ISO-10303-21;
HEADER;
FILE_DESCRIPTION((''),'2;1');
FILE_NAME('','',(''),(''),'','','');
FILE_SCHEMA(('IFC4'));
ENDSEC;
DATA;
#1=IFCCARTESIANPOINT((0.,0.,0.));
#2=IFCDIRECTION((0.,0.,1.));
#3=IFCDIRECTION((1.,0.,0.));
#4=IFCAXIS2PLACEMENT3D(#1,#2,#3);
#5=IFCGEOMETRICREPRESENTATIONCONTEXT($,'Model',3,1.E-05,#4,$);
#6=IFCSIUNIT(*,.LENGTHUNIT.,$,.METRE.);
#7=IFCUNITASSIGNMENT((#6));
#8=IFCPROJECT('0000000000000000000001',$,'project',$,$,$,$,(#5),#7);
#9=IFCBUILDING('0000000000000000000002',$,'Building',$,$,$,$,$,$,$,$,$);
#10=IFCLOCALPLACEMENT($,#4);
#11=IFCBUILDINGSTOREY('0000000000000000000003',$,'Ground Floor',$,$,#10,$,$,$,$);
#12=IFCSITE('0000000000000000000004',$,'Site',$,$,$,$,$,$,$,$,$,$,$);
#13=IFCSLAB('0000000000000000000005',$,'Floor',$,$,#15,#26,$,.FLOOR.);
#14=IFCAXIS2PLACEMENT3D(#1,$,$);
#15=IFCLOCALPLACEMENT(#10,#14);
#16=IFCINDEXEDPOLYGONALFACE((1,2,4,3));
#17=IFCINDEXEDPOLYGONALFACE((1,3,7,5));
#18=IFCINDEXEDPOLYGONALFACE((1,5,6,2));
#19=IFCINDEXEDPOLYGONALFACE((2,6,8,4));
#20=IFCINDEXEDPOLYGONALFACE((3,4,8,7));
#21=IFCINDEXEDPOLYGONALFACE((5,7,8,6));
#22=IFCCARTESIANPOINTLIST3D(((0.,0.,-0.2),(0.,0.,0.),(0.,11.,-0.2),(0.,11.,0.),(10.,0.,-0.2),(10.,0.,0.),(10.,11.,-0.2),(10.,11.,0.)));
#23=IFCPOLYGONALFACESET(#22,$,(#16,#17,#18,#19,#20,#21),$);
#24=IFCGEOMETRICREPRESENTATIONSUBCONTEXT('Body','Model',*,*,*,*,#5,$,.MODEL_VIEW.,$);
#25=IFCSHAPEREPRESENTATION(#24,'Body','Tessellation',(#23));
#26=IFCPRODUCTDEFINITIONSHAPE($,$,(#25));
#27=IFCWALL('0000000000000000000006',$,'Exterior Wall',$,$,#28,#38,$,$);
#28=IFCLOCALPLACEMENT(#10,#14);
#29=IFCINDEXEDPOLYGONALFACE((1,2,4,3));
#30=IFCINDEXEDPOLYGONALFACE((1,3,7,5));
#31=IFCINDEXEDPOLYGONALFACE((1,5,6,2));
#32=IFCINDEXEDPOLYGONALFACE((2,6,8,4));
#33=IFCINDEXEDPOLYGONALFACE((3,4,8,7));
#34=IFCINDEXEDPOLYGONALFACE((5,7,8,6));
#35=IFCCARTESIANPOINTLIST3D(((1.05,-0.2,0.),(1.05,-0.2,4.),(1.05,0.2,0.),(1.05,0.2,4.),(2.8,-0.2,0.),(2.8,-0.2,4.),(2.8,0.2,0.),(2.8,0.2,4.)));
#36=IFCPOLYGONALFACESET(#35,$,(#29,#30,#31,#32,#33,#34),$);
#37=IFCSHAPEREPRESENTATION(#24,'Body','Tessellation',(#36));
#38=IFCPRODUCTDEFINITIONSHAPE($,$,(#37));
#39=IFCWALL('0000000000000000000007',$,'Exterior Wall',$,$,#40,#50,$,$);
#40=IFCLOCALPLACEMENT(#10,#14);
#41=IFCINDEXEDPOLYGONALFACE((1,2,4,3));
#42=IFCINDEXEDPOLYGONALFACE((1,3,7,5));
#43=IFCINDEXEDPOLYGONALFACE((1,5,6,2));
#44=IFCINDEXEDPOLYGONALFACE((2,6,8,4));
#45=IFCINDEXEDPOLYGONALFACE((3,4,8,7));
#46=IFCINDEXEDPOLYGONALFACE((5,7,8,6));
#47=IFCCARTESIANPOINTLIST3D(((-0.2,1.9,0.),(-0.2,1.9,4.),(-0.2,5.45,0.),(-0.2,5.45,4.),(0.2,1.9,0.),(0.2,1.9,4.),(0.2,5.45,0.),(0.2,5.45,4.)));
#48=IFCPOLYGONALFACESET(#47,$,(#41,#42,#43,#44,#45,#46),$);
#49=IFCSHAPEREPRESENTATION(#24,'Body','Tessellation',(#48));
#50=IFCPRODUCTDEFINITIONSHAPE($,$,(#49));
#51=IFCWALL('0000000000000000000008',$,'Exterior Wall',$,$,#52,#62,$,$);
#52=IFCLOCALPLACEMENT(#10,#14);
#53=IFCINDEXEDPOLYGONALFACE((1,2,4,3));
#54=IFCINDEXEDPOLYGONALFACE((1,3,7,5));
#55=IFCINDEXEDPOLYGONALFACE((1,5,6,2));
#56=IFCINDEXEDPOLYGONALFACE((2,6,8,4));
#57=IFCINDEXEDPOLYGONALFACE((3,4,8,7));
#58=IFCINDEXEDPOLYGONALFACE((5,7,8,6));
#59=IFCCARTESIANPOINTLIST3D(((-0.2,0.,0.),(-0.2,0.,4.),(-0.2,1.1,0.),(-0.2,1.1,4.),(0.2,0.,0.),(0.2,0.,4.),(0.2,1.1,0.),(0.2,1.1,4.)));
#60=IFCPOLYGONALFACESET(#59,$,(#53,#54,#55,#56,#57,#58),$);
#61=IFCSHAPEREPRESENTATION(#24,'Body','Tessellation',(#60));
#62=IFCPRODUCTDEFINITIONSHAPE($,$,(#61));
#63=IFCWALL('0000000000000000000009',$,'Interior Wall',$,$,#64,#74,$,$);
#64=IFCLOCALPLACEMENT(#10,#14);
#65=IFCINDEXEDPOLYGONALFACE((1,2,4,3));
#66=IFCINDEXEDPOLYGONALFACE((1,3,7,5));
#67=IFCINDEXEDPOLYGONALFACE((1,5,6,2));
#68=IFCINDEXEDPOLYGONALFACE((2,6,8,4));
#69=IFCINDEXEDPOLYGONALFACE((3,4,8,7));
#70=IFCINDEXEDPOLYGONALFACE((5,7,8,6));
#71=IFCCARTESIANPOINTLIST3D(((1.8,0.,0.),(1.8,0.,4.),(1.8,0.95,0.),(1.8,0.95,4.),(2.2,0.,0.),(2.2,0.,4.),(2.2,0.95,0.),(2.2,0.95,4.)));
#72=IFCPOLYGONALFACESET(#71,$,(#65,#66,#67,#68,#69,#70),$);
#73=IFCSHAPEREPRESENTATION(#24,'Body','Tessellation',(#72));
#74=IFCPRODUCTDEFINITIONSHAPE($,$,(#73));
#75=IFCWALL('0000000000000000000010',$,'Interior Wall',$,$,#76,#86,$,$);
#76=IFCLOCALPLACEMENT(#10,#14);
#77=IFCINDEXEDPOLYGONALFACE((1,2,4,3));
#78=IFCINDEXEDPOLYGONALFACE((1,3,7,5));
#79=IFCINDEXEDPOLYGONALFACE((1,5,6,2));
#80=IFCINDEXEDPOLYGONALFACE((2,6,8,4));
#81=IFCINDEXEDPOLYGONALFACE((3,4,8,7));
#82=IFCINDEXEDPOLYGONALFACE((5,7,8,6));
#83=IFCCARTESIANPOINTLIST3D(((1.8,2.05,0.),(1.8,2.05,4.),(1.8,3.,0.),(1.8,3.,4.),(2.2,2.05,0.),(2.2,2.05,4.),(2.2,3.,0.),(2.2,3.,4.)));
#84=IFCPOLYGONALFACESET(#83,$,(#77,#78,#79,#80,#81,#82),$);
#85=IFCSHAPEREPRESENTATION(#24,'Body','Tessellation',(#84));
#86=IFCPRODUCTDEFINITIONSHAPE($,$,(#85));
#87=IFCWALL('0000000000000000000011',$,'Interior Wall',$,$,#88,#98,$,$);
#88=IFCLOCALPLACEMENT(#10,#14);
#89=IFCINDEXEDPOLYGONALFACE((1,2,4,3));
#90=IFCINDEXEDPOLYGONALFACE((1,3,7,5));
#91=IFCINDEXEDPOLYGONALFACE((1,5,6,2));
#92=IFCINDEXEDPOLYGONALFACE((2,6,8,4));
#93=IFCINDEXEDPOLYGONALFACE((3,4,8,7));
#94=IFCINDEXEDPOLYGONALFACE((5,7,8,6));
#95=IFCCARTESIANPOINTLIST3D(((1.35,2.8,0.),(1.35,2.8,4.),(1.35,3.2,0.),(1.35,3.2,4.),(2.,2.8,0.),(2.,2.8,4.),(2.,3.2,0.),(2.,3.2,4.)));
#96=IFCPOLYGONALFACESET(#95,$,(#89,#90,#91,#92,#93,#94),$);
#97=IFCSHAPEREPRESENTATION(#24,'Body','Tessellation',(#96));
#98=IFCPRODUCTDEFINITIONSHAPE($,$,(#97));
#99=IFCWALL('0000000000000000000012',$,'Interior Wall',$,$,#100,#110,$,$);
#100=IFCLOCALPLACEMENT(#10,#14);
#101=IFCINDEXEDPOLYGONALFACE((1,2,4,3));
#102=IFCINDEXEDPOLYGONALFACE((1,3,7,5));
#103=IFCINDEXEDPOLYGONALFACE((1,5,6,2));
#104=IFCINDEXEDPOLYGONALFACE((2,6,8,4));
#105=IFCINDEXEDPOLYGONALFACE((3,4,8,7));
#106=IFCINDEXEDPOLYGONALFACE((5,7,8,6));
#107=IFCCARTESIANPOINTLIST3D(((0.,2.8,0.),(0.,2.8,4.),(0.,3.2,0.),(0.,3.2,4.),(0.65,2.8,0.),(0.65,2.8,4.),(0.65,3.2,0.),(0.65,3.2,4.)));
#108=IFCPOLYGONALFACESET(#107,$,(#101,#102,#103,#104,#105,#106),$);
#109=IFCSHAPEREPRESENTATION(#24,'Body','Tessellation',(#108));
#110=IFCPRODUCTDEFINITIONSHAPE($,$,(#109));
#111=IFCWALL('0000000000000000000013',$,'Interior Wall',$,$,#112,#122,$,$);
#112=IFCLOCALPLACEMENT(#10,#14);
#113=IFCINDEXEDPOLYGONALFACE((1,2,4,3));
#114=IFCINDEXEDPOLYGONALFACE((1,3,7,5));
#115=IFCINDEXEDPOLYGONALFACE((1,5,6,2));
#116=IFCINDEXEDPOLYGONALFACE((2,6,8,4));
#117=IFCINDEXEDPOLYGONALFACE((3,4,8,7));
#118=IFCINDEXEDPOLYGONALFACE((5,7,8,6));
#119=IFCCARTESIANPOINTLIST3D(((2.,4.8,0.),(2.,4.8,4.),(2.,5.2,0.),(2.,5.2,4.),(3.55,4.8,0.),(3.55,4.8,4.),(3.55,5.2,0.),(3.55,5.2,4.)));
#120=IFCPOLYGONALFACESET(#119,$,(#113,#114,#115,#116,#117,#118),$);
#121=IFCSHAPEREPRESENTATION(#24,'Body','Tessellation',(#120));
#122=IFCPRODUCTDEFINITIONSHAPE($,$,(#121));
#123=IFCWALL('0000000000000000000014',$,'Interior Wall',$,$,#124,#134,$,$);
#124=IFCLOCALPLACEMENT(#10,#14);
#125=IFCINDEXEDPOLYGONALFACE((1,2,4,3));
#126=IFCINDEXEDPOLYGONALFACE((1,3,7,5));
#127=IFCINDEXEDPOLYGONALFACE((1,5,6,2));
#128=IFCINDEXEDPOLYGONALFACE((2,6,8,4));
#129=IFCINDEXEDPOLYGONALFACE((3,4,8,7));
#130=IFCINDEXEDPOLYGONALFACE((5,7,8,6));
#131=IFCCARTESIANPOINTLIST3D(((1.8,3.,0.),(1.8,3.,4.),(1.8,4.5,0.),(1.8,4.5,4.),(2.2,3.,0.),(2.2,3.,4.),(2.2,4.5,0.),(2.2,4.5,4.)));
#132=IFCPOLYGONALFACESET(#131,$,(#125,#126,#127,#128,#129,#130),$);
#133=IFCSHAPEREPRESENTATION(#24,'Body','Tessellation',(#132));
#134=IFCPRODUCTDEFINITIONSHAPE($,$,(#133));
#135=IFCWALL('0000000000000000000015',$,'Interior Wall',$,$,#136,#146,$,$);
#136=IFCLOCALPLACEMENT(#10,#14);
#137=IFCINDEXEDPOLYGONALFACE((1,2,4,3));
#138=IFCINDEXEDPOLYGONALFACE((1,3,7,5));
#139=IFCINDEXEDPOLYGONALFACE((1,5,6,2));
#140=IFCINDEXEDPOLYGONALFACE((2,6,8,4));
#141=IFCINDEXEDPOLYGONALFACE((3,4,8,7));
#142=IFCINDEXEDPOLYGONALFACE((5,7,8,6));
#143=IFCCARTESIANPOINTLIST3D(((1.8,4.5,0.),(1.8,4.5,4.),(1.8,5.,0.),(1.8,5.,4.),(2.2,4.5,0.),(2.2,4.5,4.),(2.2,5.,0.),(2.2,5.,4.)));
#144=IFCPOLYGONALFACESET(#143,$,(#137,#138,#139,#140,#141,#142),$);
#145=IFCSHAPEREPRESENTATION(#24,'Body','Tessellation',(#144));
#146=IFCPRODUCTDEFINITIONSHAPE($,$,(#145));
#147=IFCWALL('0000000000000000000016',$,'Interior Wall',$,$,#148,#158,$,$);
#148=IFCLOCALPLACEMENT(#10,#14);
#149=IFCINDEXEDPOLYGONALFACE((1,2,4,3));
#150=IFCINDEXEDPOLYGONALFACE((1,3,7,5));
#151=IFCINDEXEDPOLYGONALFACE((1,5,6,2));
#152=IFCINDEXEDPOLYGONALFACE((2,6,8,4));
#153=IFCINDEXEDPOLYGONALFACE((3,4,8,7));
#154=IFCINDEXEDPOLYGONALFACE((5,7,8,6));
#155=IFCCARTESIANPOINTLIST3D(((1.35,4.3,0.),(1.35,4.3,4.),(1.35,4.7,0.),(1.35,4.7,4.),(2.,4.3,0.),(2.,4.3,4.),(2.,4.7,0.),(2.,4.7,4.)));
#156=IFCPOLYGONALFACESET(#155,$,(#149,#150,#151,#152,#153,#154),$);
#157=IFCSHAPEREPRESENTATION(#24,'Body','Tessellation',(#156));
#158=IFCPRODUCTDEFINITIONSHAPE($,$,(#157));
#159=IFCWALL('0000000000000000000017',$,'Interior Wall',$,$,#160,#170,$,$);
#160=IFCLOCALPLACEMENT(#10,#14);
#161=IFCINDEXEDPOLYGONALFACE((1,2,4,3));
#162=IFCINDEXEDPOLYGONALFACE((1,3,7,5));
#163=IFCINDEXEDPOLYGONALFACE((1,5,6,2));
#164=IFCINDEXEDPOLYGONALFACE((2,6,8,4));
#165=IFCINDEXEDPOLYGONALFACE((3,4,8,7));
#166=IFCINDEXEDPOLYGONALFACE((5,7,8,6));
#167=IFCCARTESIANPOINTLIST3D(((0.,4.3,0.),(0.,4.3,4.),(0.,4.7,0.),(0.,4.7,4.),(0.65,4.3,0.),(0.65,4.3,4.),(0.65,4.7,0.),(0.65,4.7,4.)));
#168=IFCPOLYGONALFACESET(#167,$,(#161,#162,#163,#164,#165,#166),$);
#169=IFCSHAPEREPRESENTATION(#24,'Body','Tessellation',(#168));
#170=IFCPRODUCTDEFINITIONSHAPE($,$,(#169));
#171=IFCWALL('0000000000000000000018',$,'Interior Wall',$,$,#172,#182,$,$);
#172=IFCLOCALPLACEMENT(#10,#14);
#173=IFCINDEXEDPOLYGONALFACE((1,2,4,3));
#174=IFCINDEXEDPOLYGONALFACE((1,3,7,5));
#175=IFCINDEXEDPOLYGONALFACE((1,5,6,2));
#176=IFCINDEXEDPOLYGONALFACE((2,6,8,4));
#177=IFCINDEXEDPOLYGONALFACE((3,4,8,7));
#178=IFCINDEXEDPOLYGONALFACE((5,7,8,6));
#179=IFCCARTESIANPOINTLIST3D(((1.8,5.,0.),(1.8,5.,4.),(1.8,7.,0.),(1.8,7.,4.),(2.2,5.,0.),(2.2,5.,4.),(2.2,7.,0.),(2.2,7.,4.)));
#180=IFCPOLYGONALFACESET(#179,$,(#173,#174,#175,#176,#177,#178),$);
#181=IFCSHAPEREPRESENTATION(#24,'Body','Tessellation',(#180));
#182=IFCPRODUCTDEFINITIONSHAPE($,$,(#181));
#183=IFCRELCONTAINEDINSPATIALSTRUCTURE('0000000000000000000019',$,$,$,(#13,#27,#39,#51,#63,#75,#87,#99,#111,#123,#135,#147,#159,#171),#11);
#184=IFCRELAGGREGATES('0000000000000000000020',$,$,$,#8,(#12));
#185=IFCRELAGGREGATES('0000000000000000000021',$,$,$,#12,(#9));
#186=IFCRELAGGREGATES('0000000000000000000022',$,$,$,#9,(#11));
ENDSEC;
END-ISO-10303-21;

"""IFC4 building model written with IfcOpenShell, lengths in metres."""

from ifc_helpers import new_model, si_unit, frame, origin_with_axes, place, context, subcontext, project, spatial, indexed_curve, outline, extrude, element, save


model = new_model("IFC4")

# Units and contexts
model_context = context("Model", 3, precision=1e-05, world=origin_with_axes())
body_context = subcontext(model_context, "Body", "Model", "MODEL_VIEW")
ifc_project = project(units=[si_unit("LENGTHUNIT", "METRE")], contexts=[model_context])

# Site, building, storey
site = spatial("IfcSite", under=ifc_project, Name="Site")
building = spatial("IfcBuilding", under=site, Name="Building")
storey_placement = place(None, origin_with_axes())
storey = spatial("IfcBuildingStorey", under=building, at=storey_placement, Name="Ground Floor")

# Slab
slab_placement = place(storey_placement, frame((0.0, 0.0, -0.2), z_axis=(0.0, 0.0, 1.0), x_axis=(1.0, 0.0, 0.0)))
element("IfcSlab", 1, at=slab_placement, inside=storey, Name="Floor", PredefinedType="FLOOR", context=body_context, shape_type="SweptSolid", body=[
    extrude(outline(indexed_curve([(0.0, 0.0), (10.0, 0.0), (10.0, 11.0), (0.0, 11.0)])), None, (0.0, 0.0, 1.0), 0.2),
])

# Walls
wall_1_placement = place(storey_placement, frame((1.05, 0.0, 0.0), z_axis=(0.0, 0.0, 1.0), x_axis=(1.0, 0.0, 0.0)))
element("IfcWall", 2, at=wall_1_placement, inside=storey, Name="Exterior Wall", context=body_context, shape_type="SweptSolid", body=[
    extrude(outline(indexed_curve([(0.0, 0.0), (0.0, 0.4), (1.75, 0.4), (1.75, 0.0), (0.0, 0.0)], self_intersect=False)), frame((0.0, -0.2, 0.0), z_axis=(0.0, 0.0, 1.0), x_axis=(1.0, 0.0, 0.0)), (0.0, 0.0, 1.0), 4.0),
])
wall_2_placement = place(storey_placement, frame((0.0, 5.45, 0.0), z_axis=(0.0, 0.0, 1.0), x_axis=(0.0, -1.0, 0.0)))
element("IfcWall", 3, at=wall_2_placement, inside=storey, Name="Exterior Wall", context=body_context, shape_type="SweptSolid", body=[
    extrude(outline(indexed_curve([(0.0, 0.0), (0.0, 0.4), (3.55, 0.4), (3.55, 0.0), (0.0, 0.0)], self_intersect=False)), frame((0.0, -0.2, 0.0), z_axis=(0.0, 0.0, 1.0), x_axis=(1.0, 0.0, 0.0)), (0.0, 0.0, 1.0), 4.0),
])
wall_3_placement = place(storey_placement, frame((0.0, 1.1, 0.0), z_axis=(0.0, 0.0, 1.0), x_axis=(0.0, -1.0, 0.0)))
element("IfcWall", 4, at=wall_3_placement, inside=storey, Name="Exterior Wall", context=body_context, shape_type="SweptSolid", body=[
    extrude(outline(indexed_curve([(0.0, 0.0), (0.0, 0.4), (1.1, 0.4), (1.1, 0.0), (0.0, 0.0)], self_intersect=False)), frame((0.0, -0.2, 0.0), z_axis=(0.0, 0.0, 1.0), x_axis=(1.0, 0.0, 0.0)), (0.0, 0.0, 1.0), 4.0),
])
wall_4_placement = place(storey_placement, frame((2.0, 0.0, 0.0), z_axis=(0.0, 0.0, 1.0), x_axis=(0.0, 1.0, 0.0)))
element("IfcWall", 5, at=wall_4_placement, inside=storey, Name="Interior Wall", context=body_context, shape_type="SweptSolid", body=[
    extrude(outline(indexed_curve([(0.0, 0.0), (0.0, 0.4), (0.95, 0.4), (0.95, 0.0), (0.0, 0.0)], self_intersect=False)), frame((0.0, -0.2, 0.0), z_axis=(0.0, 0.0, 1.0), x_axis=(1.0, 0.0, 0.0)), (0.0, 0.0, 1.0), 4.0),
])
wall_5_placement = place(storey_placement, frame((2.0, 2.05, 0.0), z_axis=(0.0, 0.0, 1.0), x_axis=(0.0, 1.0, 0.0)))
element("IfcWall", 6, at=wall_5_placement, inside=storey, Name="Interior Wall", context=body_context, shape_type="SweptSolid", body=[
    extrude(outline(indexed_curve([(0.0, 0.0), (0.0, 0.4), (0.95, 0.4), (0.95, 0.0), (0.0, 0.0)], self_intersect=False)), frame((0.0, -0.2, 0.0), z_axis=(0.0, 0.0, 1.0), x_axis=(1.0, 0.0, 0.0)), (0.0, 0.0, 1.0), 4.0),
])
for number, where, z_axis, x_axis, name in (
    (7, (2.0, 3.0, 0.0), (0.0, 0.0, 1.0), (-1.0, 0.0, 0.0), "Interior Wall"),
    (8, (0.65, 3.0, 0.0), (0.0, 0.0, 1.0), (-1.0, 0.0, 0.0), "Interior Wall"),
):
    element("IfcWall", number, at=place(storey_placement, frame(where, z_axis=z_axis, x_axis=x_axis)), inside=storey, Name=name, context=body_context, shape_type="SweptSolid", body=[
        extrude(outline(indexed_curve([(0.0, 0.0), (0.0, 0.4), (0.65, 0.4), (0.65, 0.0), (0.0, 0.0)], self_intersect=False)), frame((0.0, -0.2, 0.0), z_axis=(0.0, 0.0, 1.0), x_axis=(1.0, 0.0, 0.0)), (0.0, 0.0, 1.0), 4.0),
    ])
wall_6_placement = place(storey_placement, frame((3.55, 5.0, 0.0), z_axis=(0.0, 0.0, 1.0), x_axis=(-1.0, 0.0, 0.0)))
element("IfcWall", 9, at=wall_6_placement, inside=storey, Name="Interior Wall", context=body_context, shape_type="SweptSolid", body=[
    extrude(outline(indexed_curve([(0.0, 0.0), (0.0, 0.4), (1.55, 0.4), (1.55, 0.0), (0.0, 0.0)], self_intersect=False)), frame((0.0, -0.2, 0.0), z_axis=(0.0, 0.0, 1.0), x_axis=(1.0, 0.0, 0.0)), (0.0, 0.0, 1.0), 4.0),
])
wall_7_placement = place(storey_placement, frame((2.0, 4.5, 0.0), z_axis=(0.0, 0.0, 1.0), x_axis=(0.0, -1.0, 0.0)))
element("IfcWall", 10, at=wall_7_placement, inside=storey, Name="Interior Wall", context=body_context, shape_type="SweptSolid", body=[
    extrude(outline(indexed_curve([(0.0, 0.0), (0.0, 0.4), (1.5, 0.4), (1.5, 0.0), (0.0, 0.0)], self_intersect=False)), frame((0.0, -0.2, 0.0), z_axis=(0.0, 0.0, 1.0), x_axis=(1.0, 0.0, 0.0)), (0.0, 0.0, 1.0), 4.0),
])
wall_8_placement = place(storey_placement, frame((2.0, 5.0, 0.0), z_axis=(0.0, 0.0, 1.0), x_axis=(0.0, -1.0, 0.0)))
element("IfcWall", 11, at=wall_8_placement, inside=storey, Name="Interior Wall", context=body_context, shape_type="SweptSolid", body=[
    extrude(outline(indexed_curve([(0.0, 0.0), (0.0, 0.4), (0.5, 0.4), (0.5, 0.0), (0.0, 0.0)], self_intersect=False)), frame((0.0, -0.2, 0.0), z_axis=(0.0, 0.0, 1.0), x_axis=(1.0, 0.0, 0.0)), (0.0, 0.0, 1.0), 4.0),
])
for number, where, z_axis, x_axis, name in (
    (12, (2.0, 4.5, 0.0), (0.0, 0.0, 1.0), (-1.0, 0.0, 0.0), "Interior Wall"),
    (13, (0.65, 4.5, 0.0), (0.0, 0.0, 1.0), (-1.0, 0.0, 0.0), "Interior Wall"),
):
    element("IfcWall", number, at=place(storey_placement, frame(where, z_axis=z_axis, x_axis=x_axis)), inside=storey, Name=name, context=body_context, shape_type="SweptSolid", body=[
        extrude(outline(indexed_curve([(0.0, 0.0), (0.0, 0.4), (0.65, 0.4), (0.65, 0.0), (0.0, 0.0)], self_intersect=False)), frame((0.0, -0.2, 0.0), z_axis=(0.0, 0.0, 1.0), x_axis=(1.0, 0.0, 0.0)), (0.0, 0.0, 1.0), 4.0),
    ])
wall_9_placement = place(storey_placement, frame((2.0, 5.0, 0.0), z_axis=(0.0, 0.0, 1.0), x_axis=(0.0, 1.0, 0.0)))
element("IfcWall", 14, at=wall_9_placement, inside=storey, Name="Interior Wall", context=body_context, shape_type="SweptSolid", body=[
    extrude(outline(indexed_curve([(0.0, 0.0), (0.0, 0.4), (2.0, 0.4), (2.0, 0.0), (0.0, 0.0)], self_intersect=False)), frame((0.0, -0.2, 0.0), z_axis=(0.0, 0.0, 1.0), x_axis=(1.0, 0.0, 0.0)), (0.0, 0.0, 1.0), 4.0),
])

save(model, "model.ifc")
